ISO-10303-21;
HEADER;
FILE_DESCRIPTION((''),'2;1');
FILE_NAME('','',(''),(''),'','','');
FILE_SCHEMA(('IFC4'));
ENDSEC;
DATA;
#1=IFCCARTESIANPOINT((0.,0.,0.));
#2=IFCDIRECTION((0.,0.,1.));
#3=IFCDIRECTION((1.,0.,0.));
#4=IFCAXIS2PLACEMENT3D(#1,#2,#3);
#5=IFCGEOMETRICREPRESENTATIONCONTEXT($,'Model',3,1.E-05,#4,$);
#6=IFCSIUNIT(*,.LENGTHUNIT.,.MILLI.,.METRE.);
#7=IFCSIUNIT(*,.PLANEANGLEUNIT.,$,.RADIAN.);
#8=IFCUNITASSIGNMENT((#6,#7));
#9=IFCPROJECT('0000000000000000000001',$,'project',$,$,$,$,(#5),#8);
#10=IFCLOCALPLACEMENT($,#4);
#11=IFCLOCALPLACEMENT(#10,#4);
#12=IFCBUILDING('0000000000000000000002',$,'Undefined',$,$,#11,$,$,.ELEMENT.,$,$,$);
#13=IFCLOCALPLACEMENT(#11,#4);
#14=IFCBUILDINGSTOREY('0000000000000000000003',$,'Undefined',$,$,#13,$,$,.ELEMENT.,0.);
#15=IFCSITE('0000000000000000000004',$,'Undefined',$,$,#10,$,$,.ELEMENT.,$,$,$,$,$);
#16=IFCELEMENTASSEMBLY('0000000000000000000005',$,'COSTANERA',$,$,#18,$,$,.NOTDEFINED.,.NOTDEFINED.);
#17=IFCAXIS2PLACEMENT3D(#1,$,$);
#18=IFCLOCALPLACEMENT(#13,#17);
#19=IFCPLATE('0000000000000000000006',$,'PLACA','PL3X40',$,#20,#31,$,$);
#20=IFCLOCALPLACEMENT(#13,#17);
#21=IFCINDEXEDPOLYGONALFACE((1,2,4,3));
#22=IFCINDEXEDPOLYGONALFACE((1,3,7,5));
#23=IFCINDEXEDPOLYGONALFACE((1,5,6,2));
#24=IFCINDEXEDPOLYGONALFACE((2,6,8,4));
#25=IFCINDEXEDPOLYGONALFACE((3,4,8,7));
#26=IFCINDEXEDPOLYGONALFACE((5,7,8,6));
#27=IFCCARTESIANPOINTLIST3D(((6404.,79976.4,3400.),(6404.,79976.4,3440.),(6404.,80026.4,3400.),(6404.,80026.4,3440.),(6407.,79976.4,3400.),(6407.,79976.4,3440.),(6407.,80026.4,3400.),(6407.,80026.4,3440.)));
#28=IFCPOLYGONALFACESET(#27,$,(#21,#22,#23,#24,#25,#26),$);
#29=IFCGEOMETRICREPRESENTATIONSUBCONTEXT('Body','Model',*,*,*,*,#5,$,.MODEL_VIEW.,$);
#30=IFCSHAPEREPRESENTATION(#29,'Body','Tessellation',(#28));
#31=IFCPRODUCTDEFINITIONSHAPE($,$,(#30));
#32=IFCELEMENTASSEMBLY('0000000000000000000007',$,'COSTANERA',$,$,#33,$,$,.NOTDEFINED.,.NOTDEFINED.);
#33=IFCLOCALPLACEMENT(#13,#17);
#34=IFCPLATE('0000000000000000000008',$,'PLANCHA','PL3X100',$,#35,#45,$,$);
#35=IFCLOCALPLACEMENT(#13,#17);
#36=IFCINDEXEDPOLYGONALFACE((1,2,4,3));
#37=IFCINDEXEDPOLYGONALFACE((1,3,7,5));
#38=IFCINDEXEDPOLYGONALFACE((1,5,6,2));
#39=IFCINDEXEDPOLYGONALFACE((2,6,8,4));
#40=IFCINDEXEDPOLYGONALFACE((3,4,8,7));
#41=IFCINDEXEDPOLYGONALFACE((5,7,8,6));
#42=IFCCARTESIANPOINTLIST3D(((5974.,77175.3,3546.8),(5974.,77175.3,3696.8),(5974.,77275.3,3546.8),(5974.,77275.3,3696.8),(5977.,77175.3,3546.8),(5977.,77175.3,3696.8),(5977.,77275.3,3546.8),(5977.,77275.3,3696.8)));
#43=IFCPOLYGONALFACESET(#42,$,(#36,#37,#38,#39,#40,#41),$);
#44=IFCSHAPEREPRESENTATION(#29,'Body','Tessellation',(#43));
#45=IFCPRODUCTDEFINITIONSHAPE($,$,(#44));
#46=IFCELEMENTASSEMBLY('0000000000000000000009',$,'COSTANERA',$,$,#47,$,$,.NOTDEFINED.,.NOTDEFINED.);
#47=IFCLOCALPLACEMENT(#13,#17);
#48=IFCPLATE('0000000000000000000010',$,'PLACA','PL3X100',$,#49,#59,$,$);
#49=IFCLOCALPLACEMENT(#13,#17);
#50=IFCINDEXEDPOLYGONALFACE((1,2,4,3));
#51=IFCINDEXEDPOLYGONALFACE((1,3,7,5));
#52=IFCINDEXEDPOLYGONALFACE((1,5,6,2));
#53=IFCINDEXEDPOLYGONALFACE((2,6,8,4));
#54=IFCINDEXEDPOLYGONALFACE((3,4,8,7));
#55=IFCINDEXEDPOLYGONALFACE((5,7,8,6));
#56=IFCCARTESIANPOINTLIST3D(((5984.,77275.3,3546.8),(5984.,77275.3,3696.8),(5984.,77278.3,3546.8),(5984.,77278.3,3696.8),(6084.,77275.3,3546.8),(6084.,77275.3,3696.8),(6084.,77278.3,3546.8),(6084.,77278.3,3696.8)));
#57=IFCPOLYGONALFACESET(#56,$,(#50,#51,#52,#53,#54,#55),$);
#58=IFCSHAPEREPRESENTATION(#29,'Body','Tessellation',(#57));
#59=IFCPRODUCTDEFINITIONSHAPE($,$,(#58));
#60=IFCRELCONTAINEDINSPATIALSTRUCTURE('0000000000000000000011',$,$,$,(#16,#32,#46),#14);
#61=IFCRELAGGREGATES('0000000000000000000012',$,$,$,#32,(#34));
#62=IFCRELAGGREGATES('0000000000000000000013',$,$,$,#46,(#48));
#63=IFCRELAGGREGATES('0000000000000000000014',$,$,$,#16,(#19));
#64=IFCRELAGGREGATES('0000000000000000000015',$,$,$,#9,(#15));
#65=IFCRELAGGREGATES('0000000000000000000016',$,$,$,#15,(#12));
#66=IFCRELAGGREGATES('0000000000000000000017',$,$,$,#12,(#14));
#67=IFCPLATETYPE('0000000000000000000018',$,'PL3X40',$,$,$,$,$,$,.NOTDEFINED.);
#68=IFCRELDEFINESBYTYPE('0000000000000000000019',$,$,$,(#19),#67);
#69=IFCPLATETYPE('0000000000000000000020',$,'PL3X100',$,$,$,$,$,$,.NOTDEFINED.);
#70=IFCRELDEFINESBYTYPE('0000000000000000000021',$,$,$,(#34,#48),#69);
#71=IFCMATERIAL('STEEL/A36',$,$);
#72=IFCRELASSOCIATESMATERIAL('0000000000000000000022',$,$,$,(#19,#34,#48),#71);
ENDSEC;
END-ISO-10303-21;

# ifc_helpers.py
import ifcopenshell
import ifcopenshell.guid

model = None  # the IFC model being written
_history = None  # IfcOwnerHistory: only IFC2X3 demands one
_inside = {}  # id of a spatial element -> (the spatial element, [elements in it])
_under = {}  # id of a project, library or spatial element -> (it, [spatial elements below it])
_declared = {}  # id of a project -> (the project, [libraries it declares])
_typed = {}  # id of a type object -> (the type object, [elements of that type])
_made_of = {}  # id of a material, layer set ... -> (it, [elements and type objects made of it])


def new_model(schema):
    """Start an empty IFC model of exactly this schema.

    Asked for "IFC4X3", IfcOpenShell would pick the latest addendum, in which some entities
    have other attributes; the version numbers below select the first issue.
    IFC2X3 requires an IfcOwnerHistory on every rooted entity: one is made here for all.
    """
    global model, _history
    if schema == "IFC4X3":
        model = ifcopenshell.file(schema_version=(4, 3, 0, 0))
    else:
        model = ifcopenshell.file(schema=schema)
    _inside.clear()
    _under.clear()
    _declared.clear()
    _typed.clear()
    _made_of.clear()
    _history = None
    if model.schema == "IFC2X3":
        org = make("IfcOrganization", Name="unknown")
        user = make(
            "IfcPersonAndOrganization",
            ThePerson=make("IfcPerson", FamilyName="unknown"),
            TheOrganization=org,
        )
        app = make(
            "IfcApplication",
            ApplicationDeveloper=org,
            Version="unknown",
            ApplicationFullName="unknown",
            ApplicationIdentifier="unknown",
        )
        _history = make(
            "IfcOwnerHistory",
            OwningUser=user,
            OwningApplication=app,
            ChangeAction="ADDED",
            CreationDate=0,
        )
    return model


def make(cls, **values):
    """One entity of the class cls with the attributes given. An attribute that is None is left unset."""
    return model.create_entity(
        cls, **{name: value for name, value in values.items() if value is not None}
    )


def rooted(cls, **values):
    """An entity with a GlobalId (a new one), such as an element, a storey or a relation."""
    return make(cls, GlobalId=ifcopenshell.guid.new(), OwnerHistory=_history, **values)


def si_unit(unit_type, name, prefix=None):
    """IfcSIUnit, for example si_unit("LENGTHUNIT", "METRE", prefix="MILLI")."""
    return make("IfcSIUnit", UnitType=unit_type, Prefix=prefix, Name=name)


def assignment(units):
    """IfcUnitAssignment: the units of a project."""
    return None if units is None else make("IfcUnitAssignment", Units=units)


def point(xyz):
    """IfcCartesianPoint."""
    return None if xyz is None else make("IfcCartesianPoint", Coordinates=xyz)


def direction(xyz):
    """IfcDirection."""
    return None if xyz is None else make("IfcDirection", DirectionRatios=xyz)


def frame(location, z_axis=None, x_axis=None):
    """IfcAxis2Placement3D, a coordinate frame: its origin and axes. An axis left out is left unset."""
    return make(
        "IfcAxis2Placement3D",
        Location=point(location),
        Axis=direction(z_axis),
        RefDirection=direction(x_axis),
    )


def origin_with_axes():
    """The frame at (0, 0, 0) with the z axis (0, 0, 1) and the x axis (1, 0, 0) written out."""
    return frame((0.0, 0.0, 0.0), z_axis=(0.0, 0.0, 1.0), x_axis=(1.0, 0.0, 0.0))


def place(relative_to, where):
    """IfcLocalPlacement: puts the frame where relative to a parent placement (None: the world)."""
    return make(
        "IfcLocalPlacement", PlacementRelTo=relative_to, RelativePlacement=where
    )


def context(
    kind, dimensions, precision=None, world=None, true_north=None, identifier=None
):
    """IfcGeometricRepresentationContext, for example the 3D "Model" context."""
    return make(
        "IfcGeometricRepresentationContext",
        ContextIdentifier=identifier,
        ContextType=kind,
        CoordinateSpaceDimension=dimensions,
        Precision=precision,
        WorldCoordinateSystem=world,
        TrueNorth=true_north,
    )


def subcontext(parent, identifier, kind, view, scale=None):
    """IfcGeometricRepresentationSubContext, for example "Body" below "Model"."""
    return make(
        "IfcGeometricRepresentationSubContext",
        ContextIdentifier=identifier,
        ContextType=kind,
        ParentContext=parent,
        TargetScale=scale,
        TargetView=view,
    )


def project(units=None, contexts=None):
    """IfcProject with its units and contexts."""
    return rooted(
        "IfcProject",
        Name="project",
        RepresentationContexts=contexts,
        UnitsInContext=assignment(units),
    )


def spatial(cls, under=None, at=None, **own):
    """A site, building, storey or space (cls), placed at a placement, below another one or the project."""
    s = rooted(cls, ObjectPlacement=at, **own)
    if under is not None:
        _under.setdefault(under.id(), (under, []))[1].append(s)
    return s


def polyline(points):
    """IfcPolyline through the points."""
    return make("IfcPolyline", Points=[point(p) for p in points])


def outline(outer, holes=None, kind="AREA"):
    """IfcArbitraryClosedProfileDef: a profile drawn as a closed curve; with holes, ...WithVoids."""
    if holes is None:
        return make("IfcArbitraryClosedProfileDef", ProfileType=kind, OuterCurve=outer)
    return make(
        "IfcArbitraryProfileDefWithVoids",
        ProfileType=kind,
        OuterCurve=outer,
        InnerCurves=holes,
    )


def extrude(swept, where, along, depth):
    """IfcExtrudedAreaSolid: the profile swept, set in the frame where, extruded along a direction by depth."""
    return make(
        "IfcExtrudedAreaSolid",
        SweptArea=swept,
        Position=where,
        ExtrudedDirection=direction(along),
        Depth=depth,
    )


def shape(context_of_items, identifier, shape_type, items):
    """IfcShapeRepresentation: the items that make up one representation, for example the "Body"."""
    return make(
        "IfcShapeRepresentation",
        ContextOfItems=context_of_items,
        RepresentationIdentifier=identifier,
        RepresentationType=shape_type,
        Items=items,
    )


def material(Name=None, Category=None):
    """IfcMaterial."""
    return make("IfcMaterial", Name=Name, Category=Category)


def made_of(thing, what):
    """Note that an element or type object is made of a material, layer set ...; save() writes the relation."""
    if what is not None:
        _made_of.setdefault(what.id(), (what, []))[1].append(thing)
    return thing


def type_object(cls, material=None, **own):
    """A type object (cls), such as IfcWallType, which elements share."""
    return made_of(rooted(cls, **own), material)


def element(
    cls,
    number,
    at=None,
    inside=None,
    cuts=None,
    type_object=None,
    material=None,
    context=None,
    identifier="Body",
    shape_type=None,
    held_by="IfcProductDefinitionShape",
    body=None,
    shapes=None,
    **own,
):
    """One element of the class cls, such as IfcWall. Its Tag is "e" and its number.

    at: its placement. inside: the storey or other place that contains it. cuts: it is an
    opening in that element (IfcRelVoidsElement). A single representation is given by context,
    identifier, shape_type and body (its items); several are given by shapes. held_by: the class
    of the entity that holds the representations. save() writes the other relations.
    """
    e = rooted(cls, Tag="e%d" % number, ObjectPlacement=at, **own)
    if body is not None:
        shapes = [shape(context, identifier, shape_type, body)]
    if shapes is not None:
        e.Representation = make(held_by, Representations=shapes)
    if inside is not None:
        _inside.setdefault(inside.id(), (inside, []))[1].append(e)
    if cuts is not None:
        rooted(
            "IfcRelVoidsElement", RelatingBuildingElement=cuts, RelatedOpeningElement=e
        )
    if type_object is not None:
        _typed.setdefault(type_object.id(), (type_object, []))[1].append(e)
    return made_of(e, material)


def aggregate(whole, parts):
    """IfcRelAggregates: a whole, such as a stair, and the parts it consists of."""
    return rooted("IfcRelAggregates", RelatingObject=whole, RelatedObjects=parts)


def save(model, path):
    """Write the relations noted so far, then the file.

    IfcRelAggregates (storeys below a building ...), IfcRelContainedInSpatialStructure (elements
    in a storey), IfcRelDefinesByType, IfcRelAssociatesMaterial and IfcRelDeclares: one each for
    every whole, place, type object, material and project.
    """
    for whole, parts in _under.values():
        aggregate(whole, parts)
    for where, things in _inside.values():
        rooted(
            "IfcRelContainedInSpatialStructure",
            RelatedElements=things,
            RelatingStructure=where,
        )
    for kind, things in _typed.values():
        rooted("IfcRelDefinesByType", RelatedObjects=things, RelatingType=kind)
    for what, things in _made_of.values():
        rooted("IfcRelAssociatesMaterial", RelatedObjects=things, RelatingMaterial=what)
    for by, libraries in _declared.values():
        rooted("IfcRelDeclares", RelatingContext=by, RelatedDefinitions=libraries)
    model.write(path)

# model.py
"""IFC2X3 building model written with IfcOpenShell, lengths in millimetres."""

from ifc_helpers import new_model, si_unit, frame, origin_with_axes, place, context, subcontext, project, spatial, polyline, outline, extrude, material, type_object, element, aggregate, save


model = new_model("IFC2X3")

# Units and contexts
model_context = context("Model", 3, precision=1e-05, world=origin_with_axes())
body_context = subcontext(model_context, "Body", "Model", "MODEL_VIEW")
ifc_project = project(units=[si_unit("LENGTHUNIT", "METRE", prefix="MILLI"), si_unit("PLANEANGLEUNIT", "RADIAN")], contexts=[model_context])

# Site, building, storey
site_placement = place(None, origin_with_axes())
site = spatial("IfcSite", under=ifc_project, at=site_placement, Name="Undefined", CompositionType="ELEMENT")
building_placement = place(site_placement, origin_with_axes())
building = spatial("IfcBuilding", under=site, at=building_placement, Name="Undefined", CompositionType="ELEMENT")
storey_placement = place(building_placement, origin_with_axes())
storey = spatial("IfcBuildingStorey", under=building, at=storey_placement, Name="Undefined", CompositionType="ELEMENT", Elevation=0.0)

# Shared definitions
ifc_material_1 = material(Name="STEEL/A36")

# Element assembly
assembly_1_placement = place(storey_placement, origin_with_axes())
assembly_1 = element("IfcElementAssembly", 1, at=assembly_1_placement, inside=storey, Name="COSTANERA", AssemblyPlace="NOTDEFINED", PredefinedType="NOTDEFINED")

# Plate
plate_type_1 = type_object("IfcPlateType", Name="PL3X40", PredefinedType="NOTDEFINED")
plate_1_placement = place(assembly_1_placement, frame((6405.5, 79976.4, 3440.0), z_axis=(1.0, 0.0, 0.0), x_axis=(0.0, 0.0, -1.0)))
plate_1 = element("IfcPlate", 2, at=plate_1_placement, type_object=plate_type_1, material=ifc_material_1, Name="PLACA", Description="PL3X40", context=body_context, shape_type="SweptSolid", body=[
    extrude(outline(polyline([(0.0, 0.0), (40.0, 0.0), (40.0, 50.0), (0.0, 50.0), (0.0, 0.0)])), frame((0.0, 0.0, -1.5), z_axis=(0.0, 0.0, 1.0), x_axis=(1.0, 0.0, 0.0)), (0.0, 0.0, 1.0), 3.0),
])

# Element assemblies, plates
assembly_2_placement = place(storey_placement, origin_with_axes())
assembly_2 = element("IfcElementAssembly", 3, at=assembly_2_placement, inside=storey, Name="COSTANERA", AssemblyPlace="NOTDEFINED", PredefinedType="NOTDEFINED")
plate_type_2 = type_object("IfcPlateType", Name="PL3X100", PredefinedType="NOTDEFINED")
plate_2_placement = place(assembly_2_placement, frame((5975.5, 77275.3, 3546.8), z_axis=(-1.0, 0.0, 0.0), x_axis=(0.0, -1.0, 0.0)))
plate_2 = element("IfcPlate", 4, at=plate_2_placement, type_object=plate_type_2, material=ifc_material_1, Name="PLANCHA", Description="PL3X100", context=body_context, shape_type="SweptSolid", body=[
    extrude(outline(polyline([(0.0, 0.0), (100.0, 0.0), (100.0, 150.0), (0.0, 150.0), (0.0, 0.0)])), frame((0.0, 0.0, -1.5), z_axis=(0.0, 0.0, 1.0), x_axis=(1.0, 0.0, 0.0)), (0.0, 0.0, 1.0), 3.0),
])
aggregate(assembly_2, [plate_2])
assembly_3_placement = place(storey_placement, origin_with_axes())
assembly_3 = element("IfcElementAssembly", 5, at=assembly_3_placement, inside=storey, Name="COSTANERA", AssemblyPlace="NOTDEFINED", PredefinedType="NOTDEFINED")
plate_3_placement = place(assembly_3_placement, frame((5984.0, 77276.8, 3546.8), z_axis=(0.0, -1.0, 0.0), x_axis=(1.0, 0.0, 0.0)))
plate_3 = element("IfcPlate", 6, at=plate_3_placement, type_object=plate_type_2, material=ifc_material_1, Name="PLACA", Description="PL3X100", context=body_context, shape_type="SweptSolid", body=[
    extrude(outline(polyline([(0.0, 0.0), (100.0, 0.0), (100.0, 150.0), (0.0, 150.0), (0.0, 0.0)])), frame((0.0, 0.0, -1.5), z_axis=(0.0, 0.0, 1.0), x_axis=(1.0, 0.0, 0.0)), (0.0, 0.0, 1.0), 3.0),
])
aggregate(assembly_3, [plate_3])

aggregate(assembly_1, [plate_1])

save(model, "model.ifc")
